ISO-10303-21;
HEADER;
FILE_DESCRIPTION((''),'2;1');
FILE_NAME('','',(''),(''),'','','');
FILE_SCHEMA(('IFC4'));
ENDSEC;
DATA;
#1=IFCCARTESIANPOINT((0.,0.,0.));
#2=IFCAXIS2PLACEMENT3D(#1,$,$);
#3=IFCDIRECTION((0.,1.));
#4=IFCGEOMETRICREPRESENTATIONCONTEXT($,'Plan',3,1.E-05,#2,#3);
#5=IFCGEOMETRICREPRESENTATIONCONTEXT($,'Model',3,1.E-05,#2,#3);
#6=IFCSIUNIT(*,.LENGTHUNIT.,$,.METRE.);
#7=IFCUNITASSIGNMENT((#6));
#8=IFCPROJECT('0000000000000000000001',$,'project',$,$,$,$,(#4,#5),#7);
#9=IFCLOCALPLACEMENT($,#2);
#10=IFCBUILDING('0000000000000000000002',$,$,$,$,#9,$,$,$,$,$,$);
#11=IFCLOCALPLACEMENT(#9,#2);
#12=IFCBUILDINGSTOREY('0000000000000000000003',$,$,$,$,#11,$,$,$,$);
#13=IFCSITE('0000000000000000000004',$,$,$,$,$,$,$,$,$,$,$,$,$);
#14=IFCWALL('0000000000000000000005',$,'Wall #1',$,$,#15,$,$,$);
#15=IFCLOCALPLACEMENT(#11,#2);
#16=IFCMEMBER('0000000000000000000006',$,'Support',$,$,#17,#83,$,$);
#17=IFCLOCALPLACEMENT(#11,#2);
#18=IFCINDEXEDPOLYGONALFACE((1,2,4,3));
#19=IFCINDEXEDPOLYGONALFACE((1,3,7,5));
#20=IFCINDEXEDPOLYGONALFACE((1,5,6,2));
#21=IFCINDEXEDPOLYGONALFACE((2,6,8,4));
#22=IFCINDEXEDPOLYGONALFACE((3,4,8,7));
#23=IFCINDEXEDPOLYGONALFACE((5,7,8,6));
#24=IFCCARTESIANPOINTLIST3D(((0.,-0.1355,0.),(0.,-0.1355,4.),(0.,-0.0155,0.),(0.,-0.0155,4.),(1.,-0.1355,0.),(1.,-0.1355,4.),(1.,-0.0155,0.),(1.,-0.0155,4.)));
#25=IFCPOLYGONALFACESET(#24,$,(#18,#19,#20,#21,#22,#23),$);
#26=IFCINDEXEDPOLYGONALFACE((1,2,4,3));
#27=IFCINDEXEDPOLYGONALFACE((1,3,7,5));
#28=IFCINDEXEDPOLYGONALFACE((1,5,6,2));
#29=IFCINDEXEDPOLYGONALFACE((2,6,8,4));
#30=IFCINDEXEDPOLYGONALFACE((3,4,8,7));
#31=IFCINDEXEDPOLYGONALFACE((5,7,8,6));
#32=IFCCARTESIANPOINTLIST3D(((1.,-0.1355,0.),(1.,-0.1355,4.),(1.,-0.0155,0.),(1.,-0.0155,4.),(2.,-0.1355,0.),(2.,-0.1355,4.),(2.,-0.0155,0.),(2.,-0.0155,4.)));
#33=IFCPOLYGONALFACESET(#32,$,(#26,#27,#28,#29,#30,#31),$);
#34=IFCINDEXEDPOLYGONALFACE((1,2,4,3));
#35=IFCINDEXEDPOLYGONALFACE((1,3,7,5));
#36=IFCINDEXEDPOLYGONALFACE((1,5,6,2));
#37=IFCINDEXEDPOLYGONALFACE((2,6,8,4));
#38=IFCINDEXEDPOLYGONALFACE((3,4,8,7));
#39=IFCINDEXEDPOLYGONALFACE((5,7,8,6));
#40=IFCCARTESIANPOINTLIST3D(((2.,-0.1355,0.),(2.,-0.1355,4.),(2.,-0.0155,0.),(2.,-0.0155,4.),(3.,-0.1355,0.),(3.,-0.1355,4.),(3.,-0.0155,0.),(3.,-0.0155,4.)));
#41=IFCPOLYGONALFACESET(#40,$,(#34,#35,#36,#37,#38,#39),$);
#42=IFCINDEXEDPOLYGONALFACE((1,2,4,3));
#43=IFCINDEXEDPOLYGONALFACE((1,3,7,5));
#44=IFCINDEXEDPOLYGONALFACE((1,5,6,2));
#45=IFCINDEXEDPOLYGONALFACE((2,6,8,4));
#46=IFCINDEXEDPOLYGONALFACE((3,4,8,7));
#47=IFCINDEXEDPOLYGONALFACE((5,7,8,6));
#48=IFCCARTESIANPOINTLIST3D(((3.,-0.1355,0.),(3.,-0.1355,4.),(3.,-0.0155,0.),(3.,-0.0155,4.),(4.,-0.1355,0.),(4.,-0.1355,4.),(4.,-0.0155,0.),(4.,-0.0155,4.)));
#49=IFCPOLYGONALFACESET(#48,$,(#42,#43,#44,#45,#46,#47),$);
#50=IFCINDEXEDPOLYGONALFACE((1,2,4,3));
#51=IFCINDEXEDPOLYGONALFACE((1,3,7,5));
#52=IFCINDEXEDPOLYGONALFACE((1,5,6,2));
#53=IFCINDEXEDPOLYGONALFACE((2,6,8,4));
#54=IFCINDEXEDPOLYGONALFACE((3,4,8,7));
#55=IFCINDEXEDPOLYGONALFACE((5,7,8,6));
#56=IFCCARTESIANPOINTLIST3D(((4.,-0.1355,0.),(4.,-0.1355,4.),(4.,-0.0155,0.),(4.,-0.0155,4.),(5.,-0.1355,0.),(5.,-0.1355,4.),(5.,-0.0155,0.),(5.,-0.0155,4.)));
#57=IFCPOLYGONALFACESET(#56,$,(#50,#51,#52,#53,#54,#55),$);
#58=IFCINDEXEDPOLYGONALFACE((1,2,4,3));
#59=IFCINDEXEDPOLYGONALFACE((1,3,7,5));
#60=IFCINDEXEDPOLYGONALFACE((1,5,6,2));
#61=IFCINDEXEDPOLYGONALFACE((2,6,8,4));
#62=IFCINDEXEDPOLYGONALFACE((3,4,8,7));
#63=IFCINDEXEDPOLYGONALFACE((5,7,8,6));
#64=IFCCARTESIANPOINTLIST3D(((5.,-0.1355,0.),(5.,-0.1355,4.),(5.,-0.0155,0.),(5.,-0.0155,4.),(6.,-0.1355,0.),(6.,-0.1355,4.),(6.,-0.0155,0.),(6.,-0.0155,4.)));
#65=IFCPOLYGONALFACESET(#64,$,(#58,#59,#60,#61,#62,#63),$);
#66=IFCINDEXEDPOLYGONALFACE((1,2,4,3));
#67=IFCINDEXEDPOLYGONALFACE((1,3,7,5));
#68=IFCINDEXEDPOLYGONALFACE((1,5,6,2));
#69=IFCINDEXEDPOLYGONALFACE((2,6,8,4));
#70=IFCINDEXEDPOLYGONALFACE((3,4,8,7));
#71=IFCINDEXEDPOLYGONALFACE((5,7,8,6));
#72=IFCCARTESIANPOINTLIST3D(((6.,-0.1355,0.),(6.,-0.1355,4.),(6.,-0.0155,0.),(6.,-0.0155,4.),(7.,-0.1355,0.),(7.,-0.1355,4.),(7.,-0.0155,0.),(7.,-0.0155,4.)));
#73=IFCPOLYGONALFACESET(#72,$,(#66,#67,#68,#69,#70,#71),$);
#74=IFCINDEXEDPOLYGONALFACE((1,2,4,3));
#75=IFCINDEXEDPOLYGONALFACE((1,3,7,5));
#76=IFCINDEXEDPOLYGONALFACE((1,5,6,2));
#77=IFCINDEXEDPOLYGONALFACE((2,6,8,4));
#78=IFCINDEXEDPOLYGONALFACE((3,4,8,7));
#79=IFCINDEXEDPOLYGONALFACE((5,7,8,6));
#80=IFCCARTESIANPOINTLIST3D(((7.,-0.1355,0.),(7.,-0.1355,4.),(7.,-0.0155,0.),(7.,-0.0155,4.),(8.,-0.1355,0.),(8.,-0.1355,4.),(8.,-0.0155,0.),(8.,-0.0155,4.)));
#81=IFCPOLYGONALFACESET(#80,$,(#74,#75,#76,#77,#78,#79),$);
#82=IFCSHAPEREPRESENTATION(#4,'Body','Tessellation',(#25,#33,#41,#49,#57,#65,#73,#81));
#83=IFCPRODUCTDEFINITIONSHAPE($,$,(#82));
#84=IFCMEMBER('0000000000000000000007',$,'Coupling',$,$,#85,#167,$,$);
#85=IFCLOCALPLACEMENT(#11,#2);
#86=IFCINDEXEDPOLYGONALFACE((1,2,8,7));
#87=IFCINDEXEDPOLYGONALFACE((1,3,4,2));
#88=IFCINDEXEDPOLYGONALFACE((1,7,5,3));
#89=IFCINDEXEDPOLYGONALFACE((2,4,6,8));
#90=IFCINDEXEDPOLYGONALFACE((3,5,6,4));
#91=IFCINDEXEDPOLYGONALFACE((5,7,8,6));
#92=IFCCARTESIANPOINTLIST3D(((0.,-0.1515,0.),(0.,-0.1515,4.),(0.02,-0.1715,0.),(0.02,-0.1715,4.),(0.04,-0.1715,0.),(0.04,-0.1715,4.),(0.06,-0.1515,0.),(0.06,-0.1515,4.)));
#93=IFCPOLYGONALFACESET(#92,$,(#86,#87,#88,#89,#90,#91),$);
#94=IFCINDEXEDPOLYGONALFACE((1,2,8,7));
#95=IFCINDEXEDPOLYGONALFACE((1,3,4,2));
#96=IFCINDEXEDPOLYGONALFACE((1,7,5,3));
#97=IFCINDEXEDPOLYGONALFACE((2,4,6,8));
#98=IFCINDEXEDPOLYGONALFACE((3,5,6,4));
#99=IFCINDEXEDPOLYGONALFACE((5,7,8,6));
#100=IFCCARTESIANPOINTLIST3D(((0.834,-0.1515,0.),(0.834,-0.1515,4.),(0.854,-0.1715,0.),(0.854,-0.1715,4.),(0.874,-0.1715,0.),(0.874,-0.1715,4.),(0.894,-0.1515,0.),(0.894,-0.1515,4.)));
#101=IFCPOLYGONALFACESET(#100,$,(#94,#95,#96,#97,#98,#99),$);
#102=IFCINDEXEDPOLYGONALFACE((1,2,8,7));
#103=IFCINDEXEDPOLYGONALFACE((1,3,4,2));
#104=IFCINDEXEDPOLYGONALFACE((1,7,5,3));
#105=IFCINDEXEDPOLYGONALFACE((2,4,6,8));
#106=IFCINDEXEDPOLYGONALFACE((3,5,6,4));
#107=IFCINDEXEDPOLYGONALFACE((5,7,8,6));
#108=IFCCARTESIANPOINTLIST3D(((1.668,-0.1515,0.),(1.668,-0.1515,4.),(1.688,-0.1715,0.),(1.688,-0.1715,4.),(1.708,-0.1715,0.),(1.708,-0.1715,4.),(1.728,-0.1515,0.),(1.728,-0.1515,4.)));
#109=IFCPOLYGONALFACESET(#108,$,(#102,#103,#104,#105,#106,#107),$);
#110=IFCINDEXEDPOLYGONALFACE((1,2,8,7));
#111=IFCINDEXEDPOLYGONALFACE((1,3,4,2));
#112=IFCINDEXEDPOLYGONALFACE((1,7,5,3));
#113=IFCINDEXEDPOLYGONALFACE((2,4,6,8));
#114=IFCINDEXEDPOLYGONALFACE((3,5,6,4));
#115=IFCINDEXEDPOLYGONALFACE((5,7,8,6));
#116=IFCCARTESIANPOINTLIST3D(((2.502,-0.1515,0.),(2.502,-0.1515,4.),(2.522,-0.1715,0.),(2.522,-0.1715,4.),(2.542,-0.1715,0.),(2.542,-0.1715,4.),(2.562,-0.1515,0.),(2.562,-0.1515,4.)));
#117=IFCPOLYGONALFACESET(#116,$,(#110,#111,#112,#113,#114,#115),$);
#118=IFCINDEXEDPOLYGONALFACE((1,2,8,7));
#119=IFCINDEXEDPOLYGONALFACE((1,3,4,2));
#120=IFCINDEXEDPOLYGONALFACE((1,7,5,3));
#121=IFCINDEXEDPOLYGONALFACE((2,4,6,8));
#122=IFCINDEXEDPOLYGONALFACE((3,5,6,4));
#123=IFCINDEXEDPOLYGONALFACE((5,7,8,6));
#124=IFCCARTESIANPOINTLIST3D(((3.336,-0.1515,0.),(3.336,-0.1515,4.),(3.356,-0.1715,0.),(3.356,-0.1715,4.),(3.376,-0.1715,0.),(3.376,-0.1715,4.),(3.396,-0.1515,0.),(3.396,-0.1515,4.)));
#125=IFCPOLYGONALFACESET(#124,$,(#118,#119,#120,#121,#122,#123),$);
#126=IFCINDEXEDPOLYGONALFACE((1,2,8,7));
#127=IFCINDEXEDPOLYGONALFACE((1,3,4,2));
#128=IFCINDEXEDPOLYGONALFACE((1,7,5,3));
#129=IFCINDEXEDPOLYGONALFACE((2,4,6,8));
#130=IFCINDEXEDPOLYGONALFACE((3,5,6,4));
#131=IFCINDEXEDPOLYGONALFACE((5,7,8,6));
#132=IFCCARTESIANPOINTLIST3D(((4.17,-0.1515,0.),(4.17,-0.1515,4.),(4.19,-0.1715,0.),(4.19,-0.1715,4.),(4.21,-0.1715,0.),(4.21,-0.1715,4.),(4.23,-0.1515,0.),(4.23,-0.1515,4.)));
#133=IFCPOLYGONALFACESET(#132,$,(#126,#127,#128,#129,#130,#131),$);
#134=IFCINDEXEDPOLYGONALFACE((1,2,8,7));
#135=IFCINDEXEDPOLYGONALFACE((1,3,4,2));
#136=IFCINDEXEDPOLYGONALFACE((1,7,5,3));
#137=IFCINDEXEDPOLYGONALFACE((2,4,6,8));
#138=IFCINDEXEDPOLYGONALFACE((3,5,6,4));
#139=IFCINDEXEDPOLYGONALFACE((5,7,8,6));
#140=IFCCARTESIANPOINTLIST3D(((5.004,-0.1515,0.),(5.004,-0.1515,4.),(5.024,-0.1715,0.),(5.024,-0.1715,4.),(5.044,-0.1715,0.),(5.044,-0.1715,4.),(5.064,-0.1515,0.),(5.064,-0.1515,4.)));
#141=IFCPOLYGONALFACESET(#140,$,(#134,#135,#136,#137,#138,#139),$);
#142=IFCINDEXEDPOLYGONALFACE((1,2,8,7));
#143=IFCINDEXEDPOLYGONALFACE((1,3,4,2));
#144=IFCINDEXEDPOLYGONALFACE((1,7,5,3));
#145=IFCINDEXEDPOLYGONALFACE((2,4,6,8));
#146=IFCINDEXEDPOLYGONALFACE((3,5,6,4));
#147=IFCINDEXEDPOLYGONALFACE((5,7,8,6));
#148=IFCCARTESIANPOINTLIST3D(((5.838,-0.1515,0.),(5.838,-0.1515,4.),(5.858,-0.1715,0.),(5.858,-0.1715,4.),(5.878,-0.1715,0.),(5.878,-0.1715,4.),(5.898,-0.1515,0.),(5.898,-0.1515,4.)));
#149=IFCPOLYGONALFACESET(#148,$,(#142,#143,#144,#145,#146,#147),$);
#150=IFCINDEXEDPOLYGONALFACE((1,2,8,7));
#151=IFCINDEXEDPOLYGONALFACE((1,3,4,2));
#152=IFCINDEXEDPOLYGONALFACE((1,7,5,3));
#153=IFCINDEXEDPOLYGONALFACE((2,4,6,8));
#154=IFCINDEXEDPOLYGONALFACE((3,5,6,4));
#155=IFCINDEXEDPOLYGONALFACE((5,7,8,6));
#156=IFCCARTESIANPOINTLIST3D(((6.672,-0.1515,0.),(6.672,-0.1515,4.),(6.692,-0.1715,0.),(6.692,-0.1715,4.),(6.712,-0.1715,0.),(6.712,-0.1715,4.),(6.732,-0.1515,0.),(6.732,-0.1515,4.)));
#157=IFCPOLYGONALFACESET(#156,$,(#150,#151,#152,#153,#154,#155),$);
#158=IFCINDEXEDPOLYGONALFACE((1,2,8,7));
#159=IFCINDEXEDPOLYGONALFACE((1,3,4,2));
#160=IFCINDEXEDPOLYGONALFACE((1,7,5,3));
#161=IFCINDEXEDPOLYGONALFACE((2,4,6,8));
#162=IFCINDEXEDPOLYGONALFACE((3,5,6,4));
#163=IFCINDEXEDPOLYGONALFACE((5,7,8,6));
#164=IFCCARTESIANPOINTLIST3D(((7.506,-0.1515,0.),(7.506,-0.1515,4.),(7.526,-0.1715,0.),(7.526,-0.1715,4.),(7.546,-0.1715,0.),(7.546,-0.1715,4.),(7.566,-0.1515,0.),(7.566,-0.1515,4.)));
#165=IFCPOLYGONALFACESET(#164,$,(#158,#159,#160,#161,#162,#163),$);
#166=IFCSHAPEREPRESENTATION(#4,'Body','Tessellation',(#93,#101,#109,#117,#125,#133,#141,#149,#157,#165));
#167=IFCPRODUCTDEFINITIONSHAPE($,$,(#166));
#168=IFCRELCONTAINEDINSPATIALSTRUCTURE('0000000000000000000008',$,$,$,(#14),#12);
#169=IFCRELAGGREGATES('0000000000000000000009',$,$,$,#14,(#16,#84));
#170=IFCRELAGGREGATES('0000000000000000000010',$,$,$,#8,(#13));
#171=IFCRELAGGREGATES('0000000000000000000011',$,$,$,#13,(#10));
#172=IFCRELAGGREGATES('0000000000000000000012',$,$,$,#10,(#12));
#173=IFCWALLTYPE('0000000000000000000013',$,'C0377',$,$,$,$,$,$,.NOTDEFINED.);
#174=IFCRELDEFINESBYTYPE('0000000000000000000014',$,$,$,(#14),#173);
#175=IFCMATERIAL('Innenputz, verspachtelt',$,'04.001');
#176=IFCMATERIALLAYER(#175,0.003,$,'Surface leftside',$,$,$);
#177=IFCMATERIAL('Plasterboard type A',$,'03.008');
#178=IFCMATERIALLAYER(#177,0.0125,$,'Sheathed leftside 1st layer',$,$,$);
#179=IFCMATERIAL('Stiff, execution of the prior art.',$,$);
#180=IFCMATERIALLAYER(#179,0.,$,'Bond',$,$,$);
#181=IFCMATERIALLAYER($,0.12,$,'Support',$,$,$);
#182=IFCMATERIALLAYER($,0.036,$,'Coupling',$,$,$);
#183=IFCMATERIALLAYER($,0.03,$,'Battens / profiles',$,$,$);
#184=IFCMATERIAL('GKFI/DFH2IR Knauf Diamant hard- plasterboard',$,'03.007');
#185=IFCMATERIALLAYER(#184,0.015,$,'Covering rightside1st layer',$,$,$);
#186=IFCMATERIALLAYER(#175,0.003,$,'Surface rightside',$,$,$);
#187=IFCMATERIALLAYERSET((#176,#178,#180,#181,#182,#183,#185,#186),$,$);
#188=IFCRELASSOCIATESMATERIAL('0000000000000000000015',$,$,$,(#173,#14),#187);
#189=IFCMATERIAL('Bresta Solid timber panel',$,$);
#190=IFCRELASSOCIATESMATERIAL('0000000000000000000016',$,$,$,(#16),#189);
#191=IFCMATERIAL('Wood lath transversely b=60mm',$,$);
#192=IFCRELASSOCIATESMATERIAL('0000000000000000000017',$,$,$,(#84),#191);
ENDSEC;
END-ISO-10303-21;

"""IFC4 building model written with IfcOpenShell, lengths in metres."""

from ifc_helpers import new_model, si_unit, direction, frame, frame_2d, origin, place, context, project, spatial, polyline, rectangle, outline, extrude, material, layer, layer_set, type_object, element, aggregate, save


model = new_model("IFC4")

# Units and contexts
plan_context = context("Plan", 3, precision=1e-05, world=origin(), true_north=direction((0.0, 1.0)))
model_context = context("Model", 3, precision=1e-05, world=origin(), true_north=direction((0.0, 1.0)))
ifc_project = project(units=[si_unit("LENGTHUNIT", "METRE")], contexts=[plan_context, model_context])

# Site, building, storey
site = spatial("IfcSite", under=ifc_project)
building_placement = place(None, origin())
building = spatial("IfcBuilding", under=site, at=building_placement)
storey_placement = place(building_placement, origin())
storey = spatial("IfcBuildingStorey", under=building, at=storey_placement)

# Wall, members
ifc_material_1 = material(Name="Innenputz, verspachtelt", Category="04.001")
ifc_layer_1 = layer(ifc_material_1, 0.003, Name="Surface leftside")
ifc_material_2 = material(Name="Plasterboard type A", Category="03.008")
ifc_layer_2 = layer(ifc_material_2, 0.0125, Name="Sheathed leftside 1st layer")
ifc_material_3 = material(Name="Stiff, execution of the prior art.")
ifc_layer_3 = layer(ifc_material_3, 0.0, Name="Bond")
ifc_layer_4 = layer(None, 0.12, Name="Support")
ifc_layer_5 = layer(None, 0.036, Name="Coupling")
ifc_layer_6 = layer(None, 0.03, Name="Battens / profiles")
ifc_material_4 = material(Name="GKFI/DFH2IR Knauf Diamant hard- plasterboard", Category="03.007")
ifc_layer_7 = layer(ifc_material_4, 0.015, Name="Covering rightside1st layer")
ifc_layer_8 = layer(ifc_material_1, 0.003, Name="Surface rightside")
ifc_layer_set = layer_set([ifc_layer_1, ifc_layer_2, ifc_layer_3, ifc_layer_4, ifc_layer_5, ifc_layer_6, ifc_layer_7, ifc_layer_8])
wall_type = type_object("IfcWallType", Name="C0377", PredefinedType="NOTDEFINED", material=ifc_layer_set)
wall_placement = place(None, frame((0.0, 0.0, 0.0), z_axis=(0.0, -1.0, 0.0), x_axis=(1.0, 0.0, 0.0)))
wall = element("IfcWall", 1, at=wall_placement, inside=storey, type_object=wall_type, material=ifc_layer_set, Name="Wall #1")
ifc_material_5 = material(Name="Bresta Solid timber panel")
member_1_placement = place(wall_placement, origin())
member_1 = element("IfcMember", 2, at=member_1_placement, material=ifc_material_5, Name="Support", context=plan_context, shape_type="SweptSolid", body=[
    extrude(rectangle(XDim=1.0, YDim=0.12, at=frame_2d((0.5, 0.06), x_axis=(1.0, 0.0))), frame((0.0, 4.0, 0.0155), z_axis=(0.0, -1.0, 0.0), x_axis=(1.0, 0.0, 0.0)), (0.0, 0.0, 1.0), 4.0),
    extrude(rectangle(XDim=1.0, YDim=0.12, at=frame_2d((0.5, 0.06), x_axis=(1.0, 0.0))), frame((1.0, 4.0, 0.0155), z_axis=(0.0, -1.0, 0.0), x_axis=(1.0, 0.0, 0.0)), (0.0, 0.0, 1.0), 4.0),
    extrude(rectangle(XDim=1.0, YDim=0.12, at=frame_2d((0.5, 0.06), x_axis=(1.0, 0.0))), frame((2.0, 4.0, 0.0155), z_axis=(0.0, -1.0, 0.0), x_axis=(1.0, 0.0, 0.0)), (0.0, 0.0, 1.0), 4.0),
    extrude(rectangle(XDim=1.0, YDim=0.12, at=frame_2d((0.5, 0.06), x_axis=(1.0, 0.0))), frame((3.0, 4.0, 0.0155), z_axis=(0.0, -1.0, 0.0), x_axis=(1.0, 0.0, 0.0)), (0.0, 0.0, 1.0), 4.0),
    extrude(rectangle(XDim=1.0, YDim=0.12, at=frame_2d((0.5, 0.06), x_axis=(1.0, 0.0))), frame((4.0, 4.0, 0.0155), z_axis=(0.0, -1.0, 0.0), x_axis=(1.0, 0.0, 0.0)), (0.0, 0.0, 1.0), 4.0),
    extrude(rectangle(XDim=1.0, YDim=0.12, at=frame_2d((0.5, 0.06), x_axis=(1.0, 0.0))), frame((5.0, 4.0, 0.0155), z_axis=(0.0, -1.0, 0.0), x_axis=(1.0, 0.0, 0.0)), (0.0, 0.0, 1.0), 4.0),
    extrude(rectangle(XDim=1.0, YDim=0.12, at=frame_2d((0.5, 0.06), x_axis=(1.0, 0.0))), frame((6.0, 4.0, 0.0155), z_axis=(0.0, -1.0, 0.0), x_axis=(1.0, 0.0, 0.0)), (0.0, 0.0, 1.0), 4.0),
    extrude(rectangle(XDim=1.0, YDim=0.12, at=frame_2d((0.5, 0.06), x_axis=(1.0, 0.0))), frame((7.0, 4.0, 0.0155), z_axis=(0.0, -1.0, 0.0), x_axis=(1.0, 0.0, 0.0)), (0.0, 0.0, 1.0), 4.0),
])
ifc_material_6 = material(Name="Wood lath transversely b=60mm")
member_2_placement = place(wall_placement, origin())
member_2 = element("IfcMember", 3, at=member_2_placement, material=ifc_material_6, Name="Coupling", context=plan_context, shape_type="SweptSolid", body=[
    extrude(outline(polyline([(0.0, 0.0), (0.06, 0.0), (0.04, 0.02), (0.02, 0.02), (0.0, 0.0)])), frame((0.0, 4.0, 0.1515), z_axis=(0.0, -1.0, 0.0), x_axis=(1.0, 0.0, 0.0)), (0.0, 0.0, 1.0), 4.0),
    extrude(outline(polyline([(0.0, 0.0), (0.06, 0.0), (0.04, 0.02), (0.02, 0.02), (0.0, 0.0)])), frame((0.834, 4.0, 0.1515), z_axis=(0.0, -1.0, 0.0), x_axis=(1.0, 0.0, 0.0)), (0.0, 0.0, 1.0), 4.0),
    extrude(outline(polyline([(0.0, 0.0), (0.06, 0.0), (0.04, 0.02), (0.02, 0.02), (0.0, 0.0)])), frame((1.668, 4.0, 0.1515), z_axis=(0.0, -1.0, 0.0), x_axis=(1.0, 0.0, 0.0)), (0.0, 0.0, 1.0), 4.0),
    extrude(outline(polyline([(0.0, 0.0), (0.06, 0.0), (0.04, 0.02), (0.02, 0.02), (0.0, 0.0)])), frame((2.502, 4.0, 0.1515), z_axis=(0.0, -1.0, 0.0), x_axis=(1.0, 0.0, 0.0)), (0.0, 0.0, 1.0), 4.0),
    extrude(outline(polyline([(0.0, 0.0), (0.06, 0.0), (0.04, 0.02), (0.02, 0.02), (0.0, 0.0)])), frame((3.336, 4.0, 0.1515), z_axis=(0.0, -1.0, 0.0), x_axis=(1.0, 0.0, 0.0)), (0.0, 0.0, 1.0), 4.0),
    extrude(outline(polyline([(0.0, 0.0), (0.06, 0.0), (0.04, 0.02), (0.02, 0.02), (0.0, 0.0)])), frame((4.17, 4.0, 0.1515), z_axis=(0.0, -1.0, 0.0), x_axis=(1.0, 0.0, 0.0)), (0.0, 0.0, 1.0), 4.0),
    extrude(outline(polyline([(0.0, 0.0), (0.06, 0.0), (0.04, 0.02), (0.02, 0.02), (0.0, 0.0)])), frame((5.004, 4.0, 0.1515), z_axis=(0.0, -1.0, 0.0), x_axis=(1.0, 0.0, 0.0)), (0.0, 0.0, 1.0), 4.0),
    extrude(outline(polyline([(0.0, 0.0), (0.06, 0.0), (0.04, 0.02), (0.02, 0.02), (0.0, 0.0)])), frame((5.838, 4.0, 0.1515), z_axis=(0.0, -1.0, 0.0), x_axis=(1.0, 0.0, 0.0)), (0.0, 0.0, 1.0), 4.0),
    extrude(outline(polyline([(0.0, 0.0), (0.06, 0.0), (0.04, 0.02), (0.02, 0.02), (0.0, 0.0)])), frame((6.672, 4.0, 0.1515), z_axis=(0.0, -1.0, 0.0), x_axis=(1.0, 0.0, 0.0)), (0.0, 0.0, 1.0), 4.0),
    extrude(outline(polyline([(0.0, 0.0), (0.06, 0.0), (0.04, 0.02), (0.02, 0.02), (0.0, 0.0)])), frame((7.506, 4.0, 0.1515), z_axis=(0.0, -1.0, 0.0), x_axis=(1.0, 0.0, 0.0)), (0.0, 0.0, 1.0), 4.0),
])
aggregate(wall, [member_1, member_2])

save(model, "model.ifc")
